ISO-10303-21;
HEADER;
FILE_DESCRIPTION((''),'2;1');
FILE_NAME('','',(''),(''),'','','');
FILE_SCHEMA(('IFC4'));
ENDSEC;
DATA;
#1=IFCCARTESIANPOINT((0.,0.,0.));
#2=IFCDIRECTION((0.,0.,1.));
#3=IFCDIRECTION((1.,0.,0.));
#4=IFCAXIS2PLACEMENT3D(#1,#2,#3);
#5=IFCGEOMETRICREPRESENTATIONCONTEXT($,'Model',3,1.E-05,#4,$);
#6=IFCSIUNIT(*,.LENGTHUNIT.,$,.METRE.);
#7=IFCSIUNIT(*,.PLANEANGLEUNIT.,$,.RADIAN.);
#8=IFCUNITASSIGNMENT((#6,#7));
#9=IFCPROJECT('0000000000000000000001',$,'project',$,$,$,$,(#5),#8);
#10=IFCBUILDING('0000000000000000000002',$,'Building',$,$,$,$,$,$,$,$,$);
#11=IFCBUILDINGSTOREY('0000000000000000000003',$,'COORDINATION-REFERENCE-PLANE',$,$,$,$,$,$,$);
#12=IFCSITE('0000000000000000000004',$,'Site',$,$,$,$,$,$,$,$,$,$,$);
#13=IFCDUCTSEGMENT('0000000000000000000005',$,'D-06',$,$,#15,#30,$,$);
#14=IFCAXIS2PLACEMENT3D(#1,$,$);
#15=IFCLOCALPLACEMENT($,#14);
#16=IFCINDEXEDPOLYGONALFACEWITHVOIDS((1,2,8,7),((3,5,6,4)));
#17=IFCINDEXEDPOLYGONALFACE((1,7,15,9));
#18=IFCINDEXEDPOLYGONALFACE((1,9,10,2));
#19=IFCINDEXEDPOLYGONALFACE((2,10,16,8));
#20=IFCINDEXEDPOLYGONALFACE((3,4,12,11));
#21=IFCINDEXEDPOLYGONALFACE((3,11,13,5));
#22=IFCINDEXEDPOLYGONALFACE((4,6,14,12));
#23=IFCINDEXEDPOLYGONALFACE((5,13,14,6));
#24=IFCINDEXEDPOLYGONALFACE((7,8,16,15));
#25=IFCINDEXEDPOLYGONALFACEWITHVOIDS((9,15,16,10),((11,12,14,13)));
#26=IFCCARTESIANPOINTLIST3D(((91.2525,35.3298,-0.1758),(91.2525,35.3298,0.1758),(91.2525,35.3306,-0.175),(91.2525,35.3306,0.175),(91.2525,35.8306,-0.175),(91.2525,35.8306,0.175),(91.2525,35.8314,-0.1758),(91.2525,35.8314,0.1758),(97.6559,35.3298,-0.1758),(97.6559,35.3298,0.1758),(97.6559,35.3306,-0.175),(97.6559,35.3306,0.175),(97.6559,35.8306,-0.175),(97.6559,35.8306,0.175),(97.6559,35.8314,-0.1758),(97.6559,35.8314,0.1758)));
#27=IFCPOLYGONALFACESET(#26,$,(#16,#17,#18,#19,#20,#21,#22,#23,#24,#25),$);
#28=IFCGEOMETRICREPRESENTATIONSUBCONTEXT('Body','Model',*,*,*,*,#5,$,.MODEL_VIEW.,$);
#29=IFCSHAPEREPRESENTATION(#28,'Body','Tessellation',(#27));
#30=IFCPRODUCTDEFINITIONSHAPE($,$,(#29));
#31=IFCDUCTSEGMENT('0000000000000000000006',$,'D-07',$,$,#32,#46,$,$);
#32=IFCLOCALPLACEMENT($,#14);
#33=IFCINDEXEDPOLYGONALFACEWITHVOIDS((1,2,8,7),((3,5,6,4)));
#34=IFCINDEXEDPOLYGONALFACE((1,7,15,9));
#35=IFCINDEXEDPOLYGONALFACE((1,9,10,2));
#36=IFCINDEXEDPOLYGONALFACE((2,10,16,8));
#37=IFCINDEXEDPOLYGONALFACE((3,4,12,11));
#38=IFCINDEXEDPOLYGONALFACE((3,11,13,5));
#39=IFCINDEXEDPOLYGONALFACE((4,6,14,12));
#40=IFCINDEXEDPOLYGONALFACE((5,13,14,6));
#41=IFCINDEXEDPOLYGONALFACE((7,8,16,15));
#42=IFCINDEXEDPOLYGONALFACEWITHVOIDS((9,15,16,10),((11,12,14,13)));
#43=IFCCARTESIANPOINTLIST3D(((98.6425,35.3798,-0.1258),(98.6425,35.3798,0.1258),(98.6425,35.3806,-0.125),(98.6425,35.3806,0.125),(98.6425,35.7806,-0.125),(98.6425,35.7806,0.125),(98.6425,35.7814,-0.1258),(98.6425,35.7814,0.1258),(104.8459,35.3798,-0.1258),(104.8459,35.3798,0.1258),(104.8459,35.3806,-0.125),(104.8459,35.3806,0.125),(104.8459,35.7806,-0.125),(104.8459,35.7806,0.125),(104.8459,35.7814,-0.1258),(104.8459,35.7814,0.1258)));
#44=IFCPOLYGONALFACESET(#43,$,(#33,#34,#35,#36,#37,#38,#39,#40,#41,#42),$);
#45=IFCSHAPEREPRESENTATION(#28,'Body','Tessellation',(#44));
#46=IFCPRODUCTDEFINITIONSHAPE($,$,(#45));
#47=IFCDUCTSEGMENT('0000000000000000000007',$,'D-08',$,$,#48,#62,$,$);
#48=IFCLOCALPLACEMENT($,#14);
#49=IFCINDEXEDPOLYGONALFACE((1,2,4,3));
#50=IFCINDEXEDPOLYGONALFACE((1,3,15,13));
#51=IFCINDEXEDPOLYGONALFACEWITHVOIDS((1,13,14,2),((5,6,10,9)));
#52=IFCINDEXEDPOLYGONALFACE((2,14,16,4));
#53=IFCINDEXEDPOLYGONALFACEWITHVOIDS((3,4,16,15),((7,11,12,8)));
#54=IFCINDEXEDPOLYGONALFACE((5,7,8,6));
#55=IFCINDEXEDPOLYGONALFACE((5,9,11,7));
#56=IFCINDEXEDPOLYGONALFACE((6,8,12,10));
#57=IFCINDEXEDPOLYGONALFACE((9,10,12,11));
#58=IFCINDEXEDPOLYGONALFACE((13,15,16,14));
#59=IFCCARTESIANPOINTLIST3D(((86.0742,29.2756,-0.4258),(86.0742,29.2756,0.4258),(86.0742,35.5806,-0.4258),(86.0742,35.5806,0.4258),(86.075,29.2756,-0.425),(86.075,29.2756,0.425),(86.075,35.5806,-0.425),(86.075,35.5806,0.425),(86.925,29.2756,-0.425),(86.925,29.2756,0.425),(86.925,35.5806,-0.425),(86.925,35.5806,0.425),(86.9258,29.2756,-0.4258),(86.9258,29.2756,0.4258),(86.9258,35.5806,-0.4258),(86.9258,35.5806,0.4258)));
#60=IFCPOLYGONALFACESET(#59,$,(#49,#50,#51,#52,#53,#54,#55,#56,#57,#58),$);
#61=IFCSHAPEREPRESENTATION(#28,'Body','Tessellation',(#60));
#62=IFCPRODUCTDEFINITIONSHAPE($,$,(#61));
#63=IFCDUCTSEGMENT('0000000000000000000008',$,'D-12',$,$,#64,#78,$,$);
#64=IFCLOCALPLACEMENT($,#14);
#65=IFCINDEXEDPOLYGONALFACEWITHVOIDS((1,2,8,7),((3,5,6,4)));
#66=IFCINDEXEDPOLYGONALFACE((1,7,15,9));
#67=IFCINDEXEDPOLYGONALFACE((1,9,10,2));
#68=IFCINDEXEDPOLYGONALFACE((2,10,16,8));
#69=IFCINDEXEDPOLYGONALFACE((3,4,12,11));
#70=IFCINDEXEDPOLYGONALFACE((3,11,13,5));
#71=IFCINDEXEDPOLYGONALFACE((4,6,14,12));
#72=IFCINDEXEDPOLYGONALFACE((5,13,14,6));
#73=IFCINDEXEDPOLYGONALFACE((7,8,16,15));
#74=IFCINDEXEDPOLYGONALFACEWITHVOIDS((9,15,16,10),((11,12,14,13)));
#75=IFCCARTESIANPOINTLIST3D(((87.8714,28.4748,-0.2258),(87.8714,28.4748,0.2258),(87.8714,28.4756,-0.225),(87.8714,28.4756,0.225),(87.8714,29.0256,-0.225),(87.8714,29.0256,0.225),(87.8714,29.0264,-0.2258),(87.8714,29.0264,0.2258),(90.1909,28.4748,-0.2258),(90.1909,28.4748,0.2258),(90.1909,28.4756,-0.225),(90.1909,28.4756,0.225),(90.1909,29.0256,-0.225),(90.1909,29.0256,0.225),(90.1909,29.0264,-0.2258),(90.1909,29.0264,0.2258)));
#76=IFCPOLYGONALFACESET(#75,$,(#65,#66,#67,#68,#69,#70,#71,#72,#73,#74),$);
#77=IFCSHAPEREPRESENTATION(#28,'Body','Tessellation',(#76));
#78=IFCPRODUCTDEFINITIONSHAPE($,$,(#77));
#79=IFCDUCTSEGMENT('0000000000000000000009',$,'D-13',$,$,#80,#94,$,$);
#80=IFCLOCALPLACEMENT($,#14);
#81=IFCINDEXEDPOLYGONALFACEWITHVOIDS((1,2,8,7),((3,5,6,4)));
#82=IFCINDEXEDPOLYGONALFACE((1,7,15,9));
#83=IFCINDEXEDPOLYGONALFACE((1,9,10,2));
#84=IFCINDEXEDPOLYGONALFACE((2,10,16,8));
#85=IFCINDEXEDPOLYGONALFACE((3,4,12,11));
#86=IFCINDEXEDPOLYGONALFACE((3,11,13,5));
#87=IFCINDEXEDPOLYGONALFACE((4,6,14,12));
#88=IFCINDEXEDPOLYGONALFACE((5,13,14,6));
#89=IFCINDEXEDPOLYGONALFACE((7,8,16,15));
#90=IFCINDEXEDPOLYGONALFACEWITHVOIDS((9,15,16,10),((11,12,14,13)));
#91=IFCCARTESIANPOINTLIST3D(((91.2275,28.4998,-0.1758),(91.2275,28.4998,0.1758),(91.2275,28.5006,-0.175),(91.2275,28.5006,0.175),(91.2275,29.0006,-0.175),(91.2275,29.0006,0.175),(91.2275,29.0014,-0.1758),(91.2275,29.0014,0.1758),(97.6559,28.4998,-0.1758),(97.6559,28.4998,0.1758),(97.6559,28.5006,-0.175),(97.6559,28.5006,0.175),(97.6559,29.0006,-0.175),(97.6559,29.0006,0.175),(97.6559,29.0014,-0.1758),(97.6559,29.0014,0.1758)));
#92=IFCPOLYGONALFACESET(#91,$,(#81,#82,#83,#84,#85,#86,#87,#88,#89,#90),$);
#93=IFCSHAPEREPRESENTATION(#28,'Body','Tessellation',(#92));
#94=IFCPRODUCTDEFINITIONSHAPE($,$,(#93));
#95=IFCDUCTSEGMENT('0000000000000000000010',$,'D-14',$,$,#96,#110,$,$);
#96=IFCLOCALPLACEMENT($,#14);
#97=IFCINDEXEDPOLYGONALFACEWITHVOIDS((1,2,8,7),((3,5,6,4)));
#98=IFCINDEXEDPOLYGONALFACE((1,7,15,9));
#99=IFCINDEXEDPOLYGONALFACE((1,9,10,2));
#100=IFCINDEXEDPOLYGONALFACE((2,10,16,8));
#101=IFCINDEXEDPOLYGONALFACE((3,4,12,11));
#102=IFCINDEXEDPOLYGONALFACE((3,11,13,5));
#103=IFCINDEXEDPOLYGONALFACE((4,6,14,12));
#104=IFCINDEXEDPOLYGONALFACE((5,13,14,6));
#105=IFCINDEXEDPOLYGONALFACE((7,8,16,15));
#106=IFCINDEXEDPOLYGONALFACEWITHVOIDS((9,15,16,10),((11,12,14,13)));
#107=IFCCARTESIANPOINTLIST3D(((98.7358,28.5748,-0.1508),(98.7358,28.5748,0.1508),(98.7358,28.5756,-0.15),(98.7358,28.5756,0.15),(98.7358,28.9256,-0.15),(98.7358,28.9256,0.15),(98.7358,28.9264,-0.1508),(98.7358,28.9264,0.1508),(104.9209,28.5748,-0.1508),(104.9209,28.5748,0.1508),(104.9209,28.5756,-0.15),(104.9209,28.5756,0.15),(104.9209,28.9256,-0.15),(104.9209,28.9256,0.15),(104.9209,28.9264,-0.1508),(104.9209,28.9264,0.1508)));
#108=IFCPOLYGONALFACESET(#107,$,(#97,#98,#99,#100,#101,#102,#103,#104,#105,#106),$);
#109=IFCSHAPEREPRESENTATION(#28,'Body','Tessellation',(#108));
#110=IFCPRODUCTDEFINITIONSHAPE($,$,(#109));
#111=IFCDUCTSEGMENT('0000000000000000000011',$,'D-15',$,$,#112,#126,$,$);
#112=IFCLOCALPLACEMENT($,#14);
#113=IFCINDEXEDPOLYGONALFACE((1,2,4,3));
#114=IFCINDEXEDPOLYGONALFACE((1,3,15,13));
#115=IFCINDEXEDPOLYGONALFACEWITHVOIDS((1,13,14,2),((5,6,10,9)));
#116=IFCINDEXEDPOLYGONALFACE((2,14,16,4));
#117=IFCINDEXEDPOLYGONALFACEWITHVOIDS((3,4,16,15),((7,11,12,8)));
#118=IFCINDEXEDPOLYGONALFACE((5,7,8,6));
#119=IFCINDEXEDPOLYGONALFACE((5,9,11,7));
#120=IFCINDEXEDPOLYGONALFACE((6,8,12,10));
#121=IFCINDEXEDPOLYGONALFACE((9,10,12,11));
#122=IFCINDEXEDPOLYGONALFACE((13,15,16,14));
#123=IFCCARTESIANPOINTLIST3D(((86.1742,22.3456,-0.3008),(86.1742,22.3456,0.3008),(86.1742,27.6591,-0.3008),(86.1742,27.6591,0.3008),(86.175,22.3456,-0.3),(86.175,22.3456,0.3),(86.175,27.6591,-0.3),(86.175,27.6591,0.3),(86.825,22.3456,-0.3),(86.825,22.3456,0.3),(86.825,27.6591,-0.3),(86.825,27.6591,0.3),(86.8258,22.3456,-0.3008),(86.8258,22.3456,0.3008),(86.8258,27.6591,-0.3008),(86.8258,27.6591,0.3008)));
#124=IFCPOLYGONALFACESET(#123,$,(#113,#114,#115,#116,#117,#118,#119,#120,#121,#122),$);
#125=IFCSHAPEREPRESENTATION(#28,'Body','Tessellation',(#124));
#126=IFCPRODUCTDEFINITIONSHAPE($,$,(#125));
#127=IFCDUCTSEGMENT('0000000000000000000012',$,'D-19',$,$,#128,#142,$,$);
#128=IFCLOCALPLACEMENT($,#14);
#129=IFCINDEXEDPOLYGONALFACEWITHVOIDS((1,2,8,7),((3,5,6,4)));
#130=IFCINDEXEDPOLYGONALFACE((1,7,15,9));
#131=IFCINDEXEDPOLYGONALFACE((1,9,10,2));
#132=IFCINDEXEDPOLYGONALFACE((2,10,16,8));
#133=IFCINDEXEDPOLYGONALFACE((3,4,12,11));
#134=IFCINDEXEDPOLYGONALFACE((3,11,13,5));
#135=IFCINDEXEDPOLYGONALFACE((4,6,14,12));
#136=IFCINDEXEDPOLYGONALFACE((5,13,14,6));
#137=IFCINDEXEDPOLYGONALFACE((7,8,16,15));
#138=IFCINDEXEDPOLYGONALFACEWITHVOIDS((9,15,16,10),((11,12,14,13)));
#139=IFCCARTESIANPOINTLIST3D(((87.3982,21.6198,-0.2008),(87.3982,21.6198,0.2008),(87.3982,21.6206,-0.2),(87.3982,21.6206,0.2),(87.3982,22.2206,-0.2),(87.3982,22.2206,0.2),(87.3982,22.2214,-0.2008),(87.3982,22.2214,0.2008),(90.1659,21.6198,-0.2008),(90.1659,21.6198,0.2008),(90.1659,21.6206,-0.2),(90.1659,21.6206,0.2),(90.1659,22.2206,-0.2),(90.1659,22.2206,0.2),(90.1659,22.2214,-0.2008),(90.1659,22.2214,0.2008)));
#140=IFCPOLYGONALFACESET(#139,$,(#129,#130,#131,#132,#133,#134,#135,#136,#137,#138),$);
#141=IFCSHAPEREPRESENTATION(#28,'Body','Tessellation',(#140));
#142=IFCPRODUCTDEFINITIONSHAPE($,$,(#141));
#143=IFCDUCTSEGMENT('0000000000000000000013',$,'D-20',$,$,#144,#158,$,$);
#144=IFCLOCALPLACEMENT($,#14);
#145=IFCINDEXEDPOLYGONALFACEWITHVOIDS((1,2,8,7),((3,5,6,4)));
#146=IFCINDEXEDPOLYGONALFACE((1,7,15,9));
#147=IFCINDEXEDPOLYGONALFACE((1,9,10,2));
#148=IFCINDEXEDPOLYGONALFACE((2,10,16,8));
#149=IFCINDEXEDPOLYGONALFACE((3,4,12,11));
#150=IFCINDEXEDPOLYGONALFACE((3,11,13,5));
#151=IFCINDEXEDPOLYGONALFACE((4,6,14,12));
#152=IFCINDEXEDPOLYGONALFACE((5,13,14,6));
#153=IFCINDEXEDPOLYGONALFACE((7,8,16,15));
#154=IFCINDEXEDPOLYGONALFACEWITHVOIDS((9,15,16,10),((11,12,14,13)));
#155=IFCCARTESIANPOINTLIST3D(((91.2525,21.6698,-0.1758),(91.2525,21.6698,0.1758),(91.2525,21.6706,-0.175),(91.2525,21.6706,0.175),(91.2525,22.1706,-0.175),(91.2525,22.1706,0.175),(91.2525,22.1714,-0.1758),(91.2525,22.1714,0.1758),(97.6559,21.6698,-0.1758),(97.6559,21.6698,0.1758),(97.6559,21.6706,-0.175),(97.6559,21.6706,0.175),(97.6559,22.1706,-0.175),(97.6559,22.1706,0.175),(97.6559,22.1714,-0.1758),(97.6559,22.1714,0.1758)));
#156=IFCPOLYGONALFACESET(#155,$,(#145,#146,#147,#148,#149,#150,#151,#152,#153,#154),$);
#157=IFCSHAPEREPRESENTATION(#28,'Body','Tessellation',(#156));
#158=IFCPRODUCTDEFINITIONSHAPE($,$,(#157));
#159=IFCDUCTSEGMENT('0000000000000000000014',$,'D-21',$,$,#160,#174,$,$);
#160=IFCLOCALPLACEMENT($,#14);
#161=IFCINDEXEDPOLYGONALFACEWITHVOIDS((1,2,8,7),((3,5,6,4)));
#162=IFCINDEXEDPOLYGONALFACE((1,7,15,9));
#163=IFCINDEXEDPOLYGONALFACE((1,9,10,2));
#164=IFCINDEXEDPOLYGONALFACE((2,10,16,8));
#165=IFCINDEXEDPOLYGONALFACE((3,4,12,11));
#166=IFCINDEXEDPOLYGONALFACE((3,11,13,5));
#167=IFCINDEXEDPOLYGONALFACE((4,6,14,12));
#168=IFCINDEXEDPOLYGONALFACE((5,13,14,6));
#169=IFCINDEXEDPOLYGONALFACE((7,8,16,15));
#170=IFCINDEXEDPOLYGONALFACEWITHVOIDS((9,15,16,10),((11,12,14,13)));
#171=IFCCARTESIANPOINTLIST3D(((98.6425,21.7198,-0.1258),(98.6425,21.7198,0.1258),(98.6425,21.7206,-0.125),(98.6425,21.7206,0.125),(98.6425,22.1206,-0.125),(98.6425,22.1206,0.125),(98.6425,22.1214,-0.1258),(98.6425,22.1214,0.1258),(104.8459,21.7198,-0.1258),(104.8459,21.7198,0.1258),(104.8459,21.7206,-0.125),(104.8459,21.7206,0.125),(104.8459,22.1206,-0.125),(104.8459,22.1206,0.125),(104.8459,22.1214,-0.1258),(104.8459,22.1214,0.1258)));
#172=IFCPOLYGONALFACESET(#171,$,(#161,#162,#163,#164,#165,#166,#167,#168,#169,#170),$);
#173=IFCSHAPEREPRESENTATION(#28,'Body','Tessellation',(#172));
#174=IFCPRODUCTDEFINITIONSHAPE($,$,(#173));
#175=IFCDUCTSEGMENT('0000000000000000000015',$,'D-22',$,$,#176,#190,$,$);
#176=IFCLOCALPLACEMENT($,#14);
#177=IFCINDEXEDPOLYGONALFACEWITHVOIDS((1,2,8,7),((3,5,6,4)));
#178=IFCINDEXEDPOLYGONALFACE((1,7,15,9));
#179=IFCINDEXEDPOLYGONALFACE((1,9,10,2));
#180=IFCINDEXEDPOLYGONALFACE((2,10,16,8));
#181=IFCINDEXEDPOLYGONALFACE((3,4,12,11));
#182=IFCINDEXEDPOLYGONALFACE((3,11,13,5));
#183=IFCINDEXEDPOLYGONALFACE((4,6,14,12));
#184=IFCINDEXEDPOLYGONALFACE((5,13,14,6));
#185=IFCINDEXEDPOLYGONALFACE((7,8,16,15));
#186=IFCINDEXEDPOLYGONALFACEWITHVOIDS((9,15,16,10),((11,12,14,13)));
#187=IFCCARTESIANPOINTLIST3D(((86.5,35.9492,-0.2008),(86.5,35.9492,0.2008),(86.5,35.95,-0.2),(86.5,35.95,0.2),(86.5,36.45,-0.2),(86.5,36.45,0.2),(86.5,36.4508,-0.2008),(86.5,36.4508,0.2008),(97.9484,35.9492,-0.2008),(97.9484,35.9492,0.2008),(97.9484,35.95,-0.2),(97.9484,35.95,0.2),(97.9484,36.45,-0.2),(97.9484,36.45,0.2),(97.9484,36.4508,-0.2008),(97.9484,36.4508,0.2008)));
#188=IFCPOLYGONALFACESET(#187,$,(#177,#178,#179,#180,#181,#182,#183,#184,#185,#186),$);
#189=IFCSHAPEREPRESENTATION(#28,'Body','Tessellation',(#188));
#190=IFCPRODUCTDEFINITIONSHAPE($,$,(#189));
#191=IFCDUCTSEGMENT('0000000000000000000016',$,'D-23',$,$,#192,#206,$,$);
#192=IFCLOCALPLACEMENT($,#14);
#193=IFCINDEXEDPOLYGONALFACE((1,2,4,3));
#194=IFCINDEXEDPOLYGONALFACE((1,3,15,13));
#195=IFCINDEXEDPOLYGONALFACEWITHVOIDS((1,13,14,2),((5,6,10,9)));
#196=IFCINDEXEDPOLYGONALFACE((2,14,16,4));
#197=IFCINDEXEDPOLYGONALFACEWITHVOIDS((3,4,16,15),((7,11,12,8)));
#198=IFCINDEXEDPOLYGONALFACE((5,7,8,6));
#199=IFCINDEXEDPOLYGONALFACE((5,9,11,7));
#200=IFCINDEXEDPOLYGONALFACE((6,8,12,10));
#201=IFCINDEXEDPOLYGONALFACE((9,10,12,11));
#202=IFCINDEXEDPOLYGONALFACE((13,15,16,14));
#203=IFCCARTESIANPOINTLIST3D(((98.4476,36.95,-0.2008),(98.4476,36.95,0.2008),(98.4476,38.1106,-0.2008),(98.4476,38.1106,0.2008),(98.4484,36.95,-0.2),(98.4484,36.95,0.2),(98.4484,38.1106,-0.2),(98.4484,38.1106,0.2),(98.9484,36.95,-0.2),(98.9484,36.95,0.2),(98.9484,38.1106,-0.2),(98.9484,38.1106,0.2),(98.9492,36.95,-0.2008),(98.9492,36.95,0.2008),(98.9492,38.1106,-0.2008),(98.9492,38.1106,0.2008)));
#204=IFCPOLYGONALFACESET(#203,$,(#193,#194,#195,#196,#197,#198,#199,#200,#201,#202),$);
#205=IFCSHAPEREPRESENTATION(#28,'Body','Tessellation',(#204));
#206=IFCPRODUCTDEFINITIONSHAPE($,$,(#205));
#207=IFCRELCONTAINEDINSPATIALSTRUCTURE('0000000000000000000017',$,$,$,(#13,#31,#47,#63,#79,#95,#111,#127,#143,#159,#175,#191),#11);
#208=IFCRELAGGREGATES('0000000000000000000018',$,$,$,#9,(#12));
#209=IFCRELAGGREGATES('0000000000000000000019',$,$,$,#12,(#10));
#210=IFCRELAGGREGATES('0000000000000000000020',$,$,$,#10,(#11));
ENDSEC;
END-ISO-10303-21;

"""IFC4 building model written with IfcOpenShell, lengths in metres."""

from ifc_helpers import new_model, si_unit, frame, origin, origin_with_axes, place, context, subcontext, project, spatial, hollow_rectangle, extrude, element, save


model = new_model("IFC4")

# Units and contexts
model_context = context("Model", 3, precision=1e-05, world=origin_with_axes())
body_context = subcontext(model_context, "Body", "Model", "MODEL_VIEW")
ifc_project = project(units=[si_unit("LENGTHUNIT", "METRE"), si_unit("PLANEANGLEUNIT", "RADIAN")], contexts=[model_context])

# Site, building, storey
site = spatial("IfcSite", under=ifc_project, Name="Site")
building = spatial("IfcBuilding", under=site, Name="Building")
storey = spatial("IfcBuildingStorey", under=building, Name="COORDINATION-REFERENCE-PLANE")

# Duct segments
duct_segment_1_placement = place(None, frame((91.2525, 35.5806, 0.0), z_axis=(1.0, 0.0, 0.0), x_axis=(0.0, 1.0, 0.0)))
element("IfcDuctSegment", 1, at=duct_segment_1_placement, inside=storey, Name="D-06", context=body_context, shape_type="SweptSolid", body=[
    extrude(hollow_rectangle(XDim=0.5016, YDim=0.3516, WallThickness=0.0008), origin(), (0.0, 0.0, 1.0), 6.4034),
])
duct_segment_2_placement = place(None, frame((98.6425, 35.5806, 0.0), z_axis=(1.0, 0.0, 0.0), x_axis=(0.0, 1.0, 0.0)))
element("IfcDuctSegment", 2, at=duct_segment_2_placement, inside=storey, Name="D-07", context=body_context, shape_type="SweptSolid", body=[
    extrude(hollow_rectangle(XDim=0.4016, YDim=0.2516, WallThickness=0.0008), origin(), (0.0, 0.0, 1.0), 6.2034),
])
duct_segment_3_placement = place(None, frame((86.5, 29.2756, 0.0), z_axis=(0.0, 1.0, 0.0), x_axis=(1.0, 0.0, 0.0)))
element("IfcDuctSegment", 3, at=duct_segment_3_placement, inside=storey, Name="D-08", context=body_context, shape_type="SweptSolid", body=[
    extrude(hollow_rectangle(XDim=0.8516, YDim=0.8516, WallThickness=0.0008), origin(), (0.0, 0.0, 1.0), 6.305),
])
duct_segment_4_placement = place(None, frame((87.8714, 28.7506, 0.0), z_axis=(1.0, 0.0, 0.0), x_axis=(0.0, 1.0, 0.0)))
element("IfcDuctSegment", 4, at=duct_segment_4_placement, inside=storey, Name="D-12", context=body_context, shape_type="SweptSolid", body=[
    extrude(hollow_rectangle(XDim=0.5516, YDim=0.4516, WallThickness=0.0008), origin(), (0.0, 0.0, 1.0), 2.3195),
])
duct_segment_5_placement = place(None, frame((91.2275, 28.7506, 0.0), z_axis=(1.0, 0.0, 0.0), x_axis=(0.0, 1.0, 0.0)))
element("IfcDuctSegment", 5, at=duct_segment_5_placement, inside=storey, Name="D-13", context=body_context, shape_type="SweptSolid", body=[
    extrude(hollow_rectangle(XDim=0.5016, YDim=0.3516, WallThickness=0.0008), origin(), (0.0, 0.0, 1.0), 6.4284),
])
duct_segment_6_placement = place(None, frame((98.7358, 28.7506, 0.0), z_axis=(1.0, 0.0, 0.0), x_axis=(0.0, 1.0, 0.0)))
element("IfcDuctSegment", 6, at=duct_segment_6_placement, inside=storey, Name="D-14", context=body_context, shape_type="SweptSolid", body=[
    extrude(hollow_rectangle(XDim=0.3516, YDim=0.3016, WallThickness=0.0008), origin(), (0.0, 0.0, 1.0), 6.1851),
])
duct_segment_7_placement = place(None, frame((86.5, 22.3456, 0.0), z_axis=(0.0, 1.0, 0.0), x_axis=(1.0, 0.0, 0.0)))
element("IfcDuctSegment", 7, at=duct_segment_7_placement, inside=storey, Name="D-15", context=body_context, shape_type="SweptSolid", body=[
    extrude(hollow_rectangle(XDim=0.6516, YDim=0.6016, WallThickness=0.0008), origin(), (0.0, 0.0, 1.0), 5.3135),
])
duct_segment_8_placement = place(None, frame((87.3982, 21.9206, 0.0), z_axis=(1.0, 0.0, 0.0), x_axis=(0.0, 1.0, 0.0)))
element("IfcDuctSegment", 8, at=duct_segment_8_placement, inside=storey, Name="D-19", context=body_context, shape_type="SweptSolid", body=[
    extrude(hollow_rectangle(XDim=0.6016, YDim=0.4016, WallThickness=0.0008), origin(), (0.0, 0.0, 1.0), 2.7677),
])
duct_segment_9_placement = place(None, frame((91.2525, 21.9206, 0.0), z_axis=(1.0, 0.0, 0.0), x_axis=(0.0, 1.0, 0.0)))
element("IfcDuctSegment", 9, at=duct_segment_9_placement, inside=storey, Name="D-20", context=body_context, shape_type="SweptSolid", body=[
    extrude(hollow_rectangle(XDim=0.5016, YDim=0.3516, WallThickness=0.0008), origin(), (0.0, 0.0, 1.0), 6.4034),
])
duct_segment_10_placement = place(None, frame((98.6425, 21.9206, 0.0), z_axis=(1.0, 0.0, 0.0), x_axis=(0.0, 1.0, 0.0)))
element("IfcDuctSegment", 10, at=duct_segment_10_placement, inside=storey, Name="D-21", context=body_context, shape_type="SweptSolid", body=[
    extrude(hollow_rectangle(XDim=0.4016, YDim=0.2516, WallThickness=0.0008), origin(), (0.0, 0.0, 1.0), 6.2034),
])
duct_segment_11_placement = place(None, frame((86.5, 36.2, 0.0), z_axis=(1.0, 0.0, 0.0), x_axis=(0.0, 1.0, 0.0)))
element("IfcDuctSegment", 11, at=duct_segment_11_placement, inside=storey, Name="D-22", context=body_context, shape_type="SweptSolid", body=[
    extrude(hollow_rectangle(XDim=0.5016, YDim=0.4016, WallThickness=0.0008), origin(), (0.0, 0.0, 1.0), 11.4484),
])
duct_segment_12_placement = place(None, frame((98.6984, 36.95, 0.0), z_axis=(0.0, 1.0, 0.0), x_axis=(1.0, 0.0, 0.0)))
element("IfcDuctSegment", 12, at=duct_segment_12_placement, inside=storey, Name="D-23", context=body_context, shape_type="SweptSolid", body=[
    extrude(hollow_rectangle(XDim=0.5016, YDim=0.4016, WallThickness=0.0008), origin(), (0.0, 0.0, 1.0), 1.1606),
])

save(model, "model.ifc")
